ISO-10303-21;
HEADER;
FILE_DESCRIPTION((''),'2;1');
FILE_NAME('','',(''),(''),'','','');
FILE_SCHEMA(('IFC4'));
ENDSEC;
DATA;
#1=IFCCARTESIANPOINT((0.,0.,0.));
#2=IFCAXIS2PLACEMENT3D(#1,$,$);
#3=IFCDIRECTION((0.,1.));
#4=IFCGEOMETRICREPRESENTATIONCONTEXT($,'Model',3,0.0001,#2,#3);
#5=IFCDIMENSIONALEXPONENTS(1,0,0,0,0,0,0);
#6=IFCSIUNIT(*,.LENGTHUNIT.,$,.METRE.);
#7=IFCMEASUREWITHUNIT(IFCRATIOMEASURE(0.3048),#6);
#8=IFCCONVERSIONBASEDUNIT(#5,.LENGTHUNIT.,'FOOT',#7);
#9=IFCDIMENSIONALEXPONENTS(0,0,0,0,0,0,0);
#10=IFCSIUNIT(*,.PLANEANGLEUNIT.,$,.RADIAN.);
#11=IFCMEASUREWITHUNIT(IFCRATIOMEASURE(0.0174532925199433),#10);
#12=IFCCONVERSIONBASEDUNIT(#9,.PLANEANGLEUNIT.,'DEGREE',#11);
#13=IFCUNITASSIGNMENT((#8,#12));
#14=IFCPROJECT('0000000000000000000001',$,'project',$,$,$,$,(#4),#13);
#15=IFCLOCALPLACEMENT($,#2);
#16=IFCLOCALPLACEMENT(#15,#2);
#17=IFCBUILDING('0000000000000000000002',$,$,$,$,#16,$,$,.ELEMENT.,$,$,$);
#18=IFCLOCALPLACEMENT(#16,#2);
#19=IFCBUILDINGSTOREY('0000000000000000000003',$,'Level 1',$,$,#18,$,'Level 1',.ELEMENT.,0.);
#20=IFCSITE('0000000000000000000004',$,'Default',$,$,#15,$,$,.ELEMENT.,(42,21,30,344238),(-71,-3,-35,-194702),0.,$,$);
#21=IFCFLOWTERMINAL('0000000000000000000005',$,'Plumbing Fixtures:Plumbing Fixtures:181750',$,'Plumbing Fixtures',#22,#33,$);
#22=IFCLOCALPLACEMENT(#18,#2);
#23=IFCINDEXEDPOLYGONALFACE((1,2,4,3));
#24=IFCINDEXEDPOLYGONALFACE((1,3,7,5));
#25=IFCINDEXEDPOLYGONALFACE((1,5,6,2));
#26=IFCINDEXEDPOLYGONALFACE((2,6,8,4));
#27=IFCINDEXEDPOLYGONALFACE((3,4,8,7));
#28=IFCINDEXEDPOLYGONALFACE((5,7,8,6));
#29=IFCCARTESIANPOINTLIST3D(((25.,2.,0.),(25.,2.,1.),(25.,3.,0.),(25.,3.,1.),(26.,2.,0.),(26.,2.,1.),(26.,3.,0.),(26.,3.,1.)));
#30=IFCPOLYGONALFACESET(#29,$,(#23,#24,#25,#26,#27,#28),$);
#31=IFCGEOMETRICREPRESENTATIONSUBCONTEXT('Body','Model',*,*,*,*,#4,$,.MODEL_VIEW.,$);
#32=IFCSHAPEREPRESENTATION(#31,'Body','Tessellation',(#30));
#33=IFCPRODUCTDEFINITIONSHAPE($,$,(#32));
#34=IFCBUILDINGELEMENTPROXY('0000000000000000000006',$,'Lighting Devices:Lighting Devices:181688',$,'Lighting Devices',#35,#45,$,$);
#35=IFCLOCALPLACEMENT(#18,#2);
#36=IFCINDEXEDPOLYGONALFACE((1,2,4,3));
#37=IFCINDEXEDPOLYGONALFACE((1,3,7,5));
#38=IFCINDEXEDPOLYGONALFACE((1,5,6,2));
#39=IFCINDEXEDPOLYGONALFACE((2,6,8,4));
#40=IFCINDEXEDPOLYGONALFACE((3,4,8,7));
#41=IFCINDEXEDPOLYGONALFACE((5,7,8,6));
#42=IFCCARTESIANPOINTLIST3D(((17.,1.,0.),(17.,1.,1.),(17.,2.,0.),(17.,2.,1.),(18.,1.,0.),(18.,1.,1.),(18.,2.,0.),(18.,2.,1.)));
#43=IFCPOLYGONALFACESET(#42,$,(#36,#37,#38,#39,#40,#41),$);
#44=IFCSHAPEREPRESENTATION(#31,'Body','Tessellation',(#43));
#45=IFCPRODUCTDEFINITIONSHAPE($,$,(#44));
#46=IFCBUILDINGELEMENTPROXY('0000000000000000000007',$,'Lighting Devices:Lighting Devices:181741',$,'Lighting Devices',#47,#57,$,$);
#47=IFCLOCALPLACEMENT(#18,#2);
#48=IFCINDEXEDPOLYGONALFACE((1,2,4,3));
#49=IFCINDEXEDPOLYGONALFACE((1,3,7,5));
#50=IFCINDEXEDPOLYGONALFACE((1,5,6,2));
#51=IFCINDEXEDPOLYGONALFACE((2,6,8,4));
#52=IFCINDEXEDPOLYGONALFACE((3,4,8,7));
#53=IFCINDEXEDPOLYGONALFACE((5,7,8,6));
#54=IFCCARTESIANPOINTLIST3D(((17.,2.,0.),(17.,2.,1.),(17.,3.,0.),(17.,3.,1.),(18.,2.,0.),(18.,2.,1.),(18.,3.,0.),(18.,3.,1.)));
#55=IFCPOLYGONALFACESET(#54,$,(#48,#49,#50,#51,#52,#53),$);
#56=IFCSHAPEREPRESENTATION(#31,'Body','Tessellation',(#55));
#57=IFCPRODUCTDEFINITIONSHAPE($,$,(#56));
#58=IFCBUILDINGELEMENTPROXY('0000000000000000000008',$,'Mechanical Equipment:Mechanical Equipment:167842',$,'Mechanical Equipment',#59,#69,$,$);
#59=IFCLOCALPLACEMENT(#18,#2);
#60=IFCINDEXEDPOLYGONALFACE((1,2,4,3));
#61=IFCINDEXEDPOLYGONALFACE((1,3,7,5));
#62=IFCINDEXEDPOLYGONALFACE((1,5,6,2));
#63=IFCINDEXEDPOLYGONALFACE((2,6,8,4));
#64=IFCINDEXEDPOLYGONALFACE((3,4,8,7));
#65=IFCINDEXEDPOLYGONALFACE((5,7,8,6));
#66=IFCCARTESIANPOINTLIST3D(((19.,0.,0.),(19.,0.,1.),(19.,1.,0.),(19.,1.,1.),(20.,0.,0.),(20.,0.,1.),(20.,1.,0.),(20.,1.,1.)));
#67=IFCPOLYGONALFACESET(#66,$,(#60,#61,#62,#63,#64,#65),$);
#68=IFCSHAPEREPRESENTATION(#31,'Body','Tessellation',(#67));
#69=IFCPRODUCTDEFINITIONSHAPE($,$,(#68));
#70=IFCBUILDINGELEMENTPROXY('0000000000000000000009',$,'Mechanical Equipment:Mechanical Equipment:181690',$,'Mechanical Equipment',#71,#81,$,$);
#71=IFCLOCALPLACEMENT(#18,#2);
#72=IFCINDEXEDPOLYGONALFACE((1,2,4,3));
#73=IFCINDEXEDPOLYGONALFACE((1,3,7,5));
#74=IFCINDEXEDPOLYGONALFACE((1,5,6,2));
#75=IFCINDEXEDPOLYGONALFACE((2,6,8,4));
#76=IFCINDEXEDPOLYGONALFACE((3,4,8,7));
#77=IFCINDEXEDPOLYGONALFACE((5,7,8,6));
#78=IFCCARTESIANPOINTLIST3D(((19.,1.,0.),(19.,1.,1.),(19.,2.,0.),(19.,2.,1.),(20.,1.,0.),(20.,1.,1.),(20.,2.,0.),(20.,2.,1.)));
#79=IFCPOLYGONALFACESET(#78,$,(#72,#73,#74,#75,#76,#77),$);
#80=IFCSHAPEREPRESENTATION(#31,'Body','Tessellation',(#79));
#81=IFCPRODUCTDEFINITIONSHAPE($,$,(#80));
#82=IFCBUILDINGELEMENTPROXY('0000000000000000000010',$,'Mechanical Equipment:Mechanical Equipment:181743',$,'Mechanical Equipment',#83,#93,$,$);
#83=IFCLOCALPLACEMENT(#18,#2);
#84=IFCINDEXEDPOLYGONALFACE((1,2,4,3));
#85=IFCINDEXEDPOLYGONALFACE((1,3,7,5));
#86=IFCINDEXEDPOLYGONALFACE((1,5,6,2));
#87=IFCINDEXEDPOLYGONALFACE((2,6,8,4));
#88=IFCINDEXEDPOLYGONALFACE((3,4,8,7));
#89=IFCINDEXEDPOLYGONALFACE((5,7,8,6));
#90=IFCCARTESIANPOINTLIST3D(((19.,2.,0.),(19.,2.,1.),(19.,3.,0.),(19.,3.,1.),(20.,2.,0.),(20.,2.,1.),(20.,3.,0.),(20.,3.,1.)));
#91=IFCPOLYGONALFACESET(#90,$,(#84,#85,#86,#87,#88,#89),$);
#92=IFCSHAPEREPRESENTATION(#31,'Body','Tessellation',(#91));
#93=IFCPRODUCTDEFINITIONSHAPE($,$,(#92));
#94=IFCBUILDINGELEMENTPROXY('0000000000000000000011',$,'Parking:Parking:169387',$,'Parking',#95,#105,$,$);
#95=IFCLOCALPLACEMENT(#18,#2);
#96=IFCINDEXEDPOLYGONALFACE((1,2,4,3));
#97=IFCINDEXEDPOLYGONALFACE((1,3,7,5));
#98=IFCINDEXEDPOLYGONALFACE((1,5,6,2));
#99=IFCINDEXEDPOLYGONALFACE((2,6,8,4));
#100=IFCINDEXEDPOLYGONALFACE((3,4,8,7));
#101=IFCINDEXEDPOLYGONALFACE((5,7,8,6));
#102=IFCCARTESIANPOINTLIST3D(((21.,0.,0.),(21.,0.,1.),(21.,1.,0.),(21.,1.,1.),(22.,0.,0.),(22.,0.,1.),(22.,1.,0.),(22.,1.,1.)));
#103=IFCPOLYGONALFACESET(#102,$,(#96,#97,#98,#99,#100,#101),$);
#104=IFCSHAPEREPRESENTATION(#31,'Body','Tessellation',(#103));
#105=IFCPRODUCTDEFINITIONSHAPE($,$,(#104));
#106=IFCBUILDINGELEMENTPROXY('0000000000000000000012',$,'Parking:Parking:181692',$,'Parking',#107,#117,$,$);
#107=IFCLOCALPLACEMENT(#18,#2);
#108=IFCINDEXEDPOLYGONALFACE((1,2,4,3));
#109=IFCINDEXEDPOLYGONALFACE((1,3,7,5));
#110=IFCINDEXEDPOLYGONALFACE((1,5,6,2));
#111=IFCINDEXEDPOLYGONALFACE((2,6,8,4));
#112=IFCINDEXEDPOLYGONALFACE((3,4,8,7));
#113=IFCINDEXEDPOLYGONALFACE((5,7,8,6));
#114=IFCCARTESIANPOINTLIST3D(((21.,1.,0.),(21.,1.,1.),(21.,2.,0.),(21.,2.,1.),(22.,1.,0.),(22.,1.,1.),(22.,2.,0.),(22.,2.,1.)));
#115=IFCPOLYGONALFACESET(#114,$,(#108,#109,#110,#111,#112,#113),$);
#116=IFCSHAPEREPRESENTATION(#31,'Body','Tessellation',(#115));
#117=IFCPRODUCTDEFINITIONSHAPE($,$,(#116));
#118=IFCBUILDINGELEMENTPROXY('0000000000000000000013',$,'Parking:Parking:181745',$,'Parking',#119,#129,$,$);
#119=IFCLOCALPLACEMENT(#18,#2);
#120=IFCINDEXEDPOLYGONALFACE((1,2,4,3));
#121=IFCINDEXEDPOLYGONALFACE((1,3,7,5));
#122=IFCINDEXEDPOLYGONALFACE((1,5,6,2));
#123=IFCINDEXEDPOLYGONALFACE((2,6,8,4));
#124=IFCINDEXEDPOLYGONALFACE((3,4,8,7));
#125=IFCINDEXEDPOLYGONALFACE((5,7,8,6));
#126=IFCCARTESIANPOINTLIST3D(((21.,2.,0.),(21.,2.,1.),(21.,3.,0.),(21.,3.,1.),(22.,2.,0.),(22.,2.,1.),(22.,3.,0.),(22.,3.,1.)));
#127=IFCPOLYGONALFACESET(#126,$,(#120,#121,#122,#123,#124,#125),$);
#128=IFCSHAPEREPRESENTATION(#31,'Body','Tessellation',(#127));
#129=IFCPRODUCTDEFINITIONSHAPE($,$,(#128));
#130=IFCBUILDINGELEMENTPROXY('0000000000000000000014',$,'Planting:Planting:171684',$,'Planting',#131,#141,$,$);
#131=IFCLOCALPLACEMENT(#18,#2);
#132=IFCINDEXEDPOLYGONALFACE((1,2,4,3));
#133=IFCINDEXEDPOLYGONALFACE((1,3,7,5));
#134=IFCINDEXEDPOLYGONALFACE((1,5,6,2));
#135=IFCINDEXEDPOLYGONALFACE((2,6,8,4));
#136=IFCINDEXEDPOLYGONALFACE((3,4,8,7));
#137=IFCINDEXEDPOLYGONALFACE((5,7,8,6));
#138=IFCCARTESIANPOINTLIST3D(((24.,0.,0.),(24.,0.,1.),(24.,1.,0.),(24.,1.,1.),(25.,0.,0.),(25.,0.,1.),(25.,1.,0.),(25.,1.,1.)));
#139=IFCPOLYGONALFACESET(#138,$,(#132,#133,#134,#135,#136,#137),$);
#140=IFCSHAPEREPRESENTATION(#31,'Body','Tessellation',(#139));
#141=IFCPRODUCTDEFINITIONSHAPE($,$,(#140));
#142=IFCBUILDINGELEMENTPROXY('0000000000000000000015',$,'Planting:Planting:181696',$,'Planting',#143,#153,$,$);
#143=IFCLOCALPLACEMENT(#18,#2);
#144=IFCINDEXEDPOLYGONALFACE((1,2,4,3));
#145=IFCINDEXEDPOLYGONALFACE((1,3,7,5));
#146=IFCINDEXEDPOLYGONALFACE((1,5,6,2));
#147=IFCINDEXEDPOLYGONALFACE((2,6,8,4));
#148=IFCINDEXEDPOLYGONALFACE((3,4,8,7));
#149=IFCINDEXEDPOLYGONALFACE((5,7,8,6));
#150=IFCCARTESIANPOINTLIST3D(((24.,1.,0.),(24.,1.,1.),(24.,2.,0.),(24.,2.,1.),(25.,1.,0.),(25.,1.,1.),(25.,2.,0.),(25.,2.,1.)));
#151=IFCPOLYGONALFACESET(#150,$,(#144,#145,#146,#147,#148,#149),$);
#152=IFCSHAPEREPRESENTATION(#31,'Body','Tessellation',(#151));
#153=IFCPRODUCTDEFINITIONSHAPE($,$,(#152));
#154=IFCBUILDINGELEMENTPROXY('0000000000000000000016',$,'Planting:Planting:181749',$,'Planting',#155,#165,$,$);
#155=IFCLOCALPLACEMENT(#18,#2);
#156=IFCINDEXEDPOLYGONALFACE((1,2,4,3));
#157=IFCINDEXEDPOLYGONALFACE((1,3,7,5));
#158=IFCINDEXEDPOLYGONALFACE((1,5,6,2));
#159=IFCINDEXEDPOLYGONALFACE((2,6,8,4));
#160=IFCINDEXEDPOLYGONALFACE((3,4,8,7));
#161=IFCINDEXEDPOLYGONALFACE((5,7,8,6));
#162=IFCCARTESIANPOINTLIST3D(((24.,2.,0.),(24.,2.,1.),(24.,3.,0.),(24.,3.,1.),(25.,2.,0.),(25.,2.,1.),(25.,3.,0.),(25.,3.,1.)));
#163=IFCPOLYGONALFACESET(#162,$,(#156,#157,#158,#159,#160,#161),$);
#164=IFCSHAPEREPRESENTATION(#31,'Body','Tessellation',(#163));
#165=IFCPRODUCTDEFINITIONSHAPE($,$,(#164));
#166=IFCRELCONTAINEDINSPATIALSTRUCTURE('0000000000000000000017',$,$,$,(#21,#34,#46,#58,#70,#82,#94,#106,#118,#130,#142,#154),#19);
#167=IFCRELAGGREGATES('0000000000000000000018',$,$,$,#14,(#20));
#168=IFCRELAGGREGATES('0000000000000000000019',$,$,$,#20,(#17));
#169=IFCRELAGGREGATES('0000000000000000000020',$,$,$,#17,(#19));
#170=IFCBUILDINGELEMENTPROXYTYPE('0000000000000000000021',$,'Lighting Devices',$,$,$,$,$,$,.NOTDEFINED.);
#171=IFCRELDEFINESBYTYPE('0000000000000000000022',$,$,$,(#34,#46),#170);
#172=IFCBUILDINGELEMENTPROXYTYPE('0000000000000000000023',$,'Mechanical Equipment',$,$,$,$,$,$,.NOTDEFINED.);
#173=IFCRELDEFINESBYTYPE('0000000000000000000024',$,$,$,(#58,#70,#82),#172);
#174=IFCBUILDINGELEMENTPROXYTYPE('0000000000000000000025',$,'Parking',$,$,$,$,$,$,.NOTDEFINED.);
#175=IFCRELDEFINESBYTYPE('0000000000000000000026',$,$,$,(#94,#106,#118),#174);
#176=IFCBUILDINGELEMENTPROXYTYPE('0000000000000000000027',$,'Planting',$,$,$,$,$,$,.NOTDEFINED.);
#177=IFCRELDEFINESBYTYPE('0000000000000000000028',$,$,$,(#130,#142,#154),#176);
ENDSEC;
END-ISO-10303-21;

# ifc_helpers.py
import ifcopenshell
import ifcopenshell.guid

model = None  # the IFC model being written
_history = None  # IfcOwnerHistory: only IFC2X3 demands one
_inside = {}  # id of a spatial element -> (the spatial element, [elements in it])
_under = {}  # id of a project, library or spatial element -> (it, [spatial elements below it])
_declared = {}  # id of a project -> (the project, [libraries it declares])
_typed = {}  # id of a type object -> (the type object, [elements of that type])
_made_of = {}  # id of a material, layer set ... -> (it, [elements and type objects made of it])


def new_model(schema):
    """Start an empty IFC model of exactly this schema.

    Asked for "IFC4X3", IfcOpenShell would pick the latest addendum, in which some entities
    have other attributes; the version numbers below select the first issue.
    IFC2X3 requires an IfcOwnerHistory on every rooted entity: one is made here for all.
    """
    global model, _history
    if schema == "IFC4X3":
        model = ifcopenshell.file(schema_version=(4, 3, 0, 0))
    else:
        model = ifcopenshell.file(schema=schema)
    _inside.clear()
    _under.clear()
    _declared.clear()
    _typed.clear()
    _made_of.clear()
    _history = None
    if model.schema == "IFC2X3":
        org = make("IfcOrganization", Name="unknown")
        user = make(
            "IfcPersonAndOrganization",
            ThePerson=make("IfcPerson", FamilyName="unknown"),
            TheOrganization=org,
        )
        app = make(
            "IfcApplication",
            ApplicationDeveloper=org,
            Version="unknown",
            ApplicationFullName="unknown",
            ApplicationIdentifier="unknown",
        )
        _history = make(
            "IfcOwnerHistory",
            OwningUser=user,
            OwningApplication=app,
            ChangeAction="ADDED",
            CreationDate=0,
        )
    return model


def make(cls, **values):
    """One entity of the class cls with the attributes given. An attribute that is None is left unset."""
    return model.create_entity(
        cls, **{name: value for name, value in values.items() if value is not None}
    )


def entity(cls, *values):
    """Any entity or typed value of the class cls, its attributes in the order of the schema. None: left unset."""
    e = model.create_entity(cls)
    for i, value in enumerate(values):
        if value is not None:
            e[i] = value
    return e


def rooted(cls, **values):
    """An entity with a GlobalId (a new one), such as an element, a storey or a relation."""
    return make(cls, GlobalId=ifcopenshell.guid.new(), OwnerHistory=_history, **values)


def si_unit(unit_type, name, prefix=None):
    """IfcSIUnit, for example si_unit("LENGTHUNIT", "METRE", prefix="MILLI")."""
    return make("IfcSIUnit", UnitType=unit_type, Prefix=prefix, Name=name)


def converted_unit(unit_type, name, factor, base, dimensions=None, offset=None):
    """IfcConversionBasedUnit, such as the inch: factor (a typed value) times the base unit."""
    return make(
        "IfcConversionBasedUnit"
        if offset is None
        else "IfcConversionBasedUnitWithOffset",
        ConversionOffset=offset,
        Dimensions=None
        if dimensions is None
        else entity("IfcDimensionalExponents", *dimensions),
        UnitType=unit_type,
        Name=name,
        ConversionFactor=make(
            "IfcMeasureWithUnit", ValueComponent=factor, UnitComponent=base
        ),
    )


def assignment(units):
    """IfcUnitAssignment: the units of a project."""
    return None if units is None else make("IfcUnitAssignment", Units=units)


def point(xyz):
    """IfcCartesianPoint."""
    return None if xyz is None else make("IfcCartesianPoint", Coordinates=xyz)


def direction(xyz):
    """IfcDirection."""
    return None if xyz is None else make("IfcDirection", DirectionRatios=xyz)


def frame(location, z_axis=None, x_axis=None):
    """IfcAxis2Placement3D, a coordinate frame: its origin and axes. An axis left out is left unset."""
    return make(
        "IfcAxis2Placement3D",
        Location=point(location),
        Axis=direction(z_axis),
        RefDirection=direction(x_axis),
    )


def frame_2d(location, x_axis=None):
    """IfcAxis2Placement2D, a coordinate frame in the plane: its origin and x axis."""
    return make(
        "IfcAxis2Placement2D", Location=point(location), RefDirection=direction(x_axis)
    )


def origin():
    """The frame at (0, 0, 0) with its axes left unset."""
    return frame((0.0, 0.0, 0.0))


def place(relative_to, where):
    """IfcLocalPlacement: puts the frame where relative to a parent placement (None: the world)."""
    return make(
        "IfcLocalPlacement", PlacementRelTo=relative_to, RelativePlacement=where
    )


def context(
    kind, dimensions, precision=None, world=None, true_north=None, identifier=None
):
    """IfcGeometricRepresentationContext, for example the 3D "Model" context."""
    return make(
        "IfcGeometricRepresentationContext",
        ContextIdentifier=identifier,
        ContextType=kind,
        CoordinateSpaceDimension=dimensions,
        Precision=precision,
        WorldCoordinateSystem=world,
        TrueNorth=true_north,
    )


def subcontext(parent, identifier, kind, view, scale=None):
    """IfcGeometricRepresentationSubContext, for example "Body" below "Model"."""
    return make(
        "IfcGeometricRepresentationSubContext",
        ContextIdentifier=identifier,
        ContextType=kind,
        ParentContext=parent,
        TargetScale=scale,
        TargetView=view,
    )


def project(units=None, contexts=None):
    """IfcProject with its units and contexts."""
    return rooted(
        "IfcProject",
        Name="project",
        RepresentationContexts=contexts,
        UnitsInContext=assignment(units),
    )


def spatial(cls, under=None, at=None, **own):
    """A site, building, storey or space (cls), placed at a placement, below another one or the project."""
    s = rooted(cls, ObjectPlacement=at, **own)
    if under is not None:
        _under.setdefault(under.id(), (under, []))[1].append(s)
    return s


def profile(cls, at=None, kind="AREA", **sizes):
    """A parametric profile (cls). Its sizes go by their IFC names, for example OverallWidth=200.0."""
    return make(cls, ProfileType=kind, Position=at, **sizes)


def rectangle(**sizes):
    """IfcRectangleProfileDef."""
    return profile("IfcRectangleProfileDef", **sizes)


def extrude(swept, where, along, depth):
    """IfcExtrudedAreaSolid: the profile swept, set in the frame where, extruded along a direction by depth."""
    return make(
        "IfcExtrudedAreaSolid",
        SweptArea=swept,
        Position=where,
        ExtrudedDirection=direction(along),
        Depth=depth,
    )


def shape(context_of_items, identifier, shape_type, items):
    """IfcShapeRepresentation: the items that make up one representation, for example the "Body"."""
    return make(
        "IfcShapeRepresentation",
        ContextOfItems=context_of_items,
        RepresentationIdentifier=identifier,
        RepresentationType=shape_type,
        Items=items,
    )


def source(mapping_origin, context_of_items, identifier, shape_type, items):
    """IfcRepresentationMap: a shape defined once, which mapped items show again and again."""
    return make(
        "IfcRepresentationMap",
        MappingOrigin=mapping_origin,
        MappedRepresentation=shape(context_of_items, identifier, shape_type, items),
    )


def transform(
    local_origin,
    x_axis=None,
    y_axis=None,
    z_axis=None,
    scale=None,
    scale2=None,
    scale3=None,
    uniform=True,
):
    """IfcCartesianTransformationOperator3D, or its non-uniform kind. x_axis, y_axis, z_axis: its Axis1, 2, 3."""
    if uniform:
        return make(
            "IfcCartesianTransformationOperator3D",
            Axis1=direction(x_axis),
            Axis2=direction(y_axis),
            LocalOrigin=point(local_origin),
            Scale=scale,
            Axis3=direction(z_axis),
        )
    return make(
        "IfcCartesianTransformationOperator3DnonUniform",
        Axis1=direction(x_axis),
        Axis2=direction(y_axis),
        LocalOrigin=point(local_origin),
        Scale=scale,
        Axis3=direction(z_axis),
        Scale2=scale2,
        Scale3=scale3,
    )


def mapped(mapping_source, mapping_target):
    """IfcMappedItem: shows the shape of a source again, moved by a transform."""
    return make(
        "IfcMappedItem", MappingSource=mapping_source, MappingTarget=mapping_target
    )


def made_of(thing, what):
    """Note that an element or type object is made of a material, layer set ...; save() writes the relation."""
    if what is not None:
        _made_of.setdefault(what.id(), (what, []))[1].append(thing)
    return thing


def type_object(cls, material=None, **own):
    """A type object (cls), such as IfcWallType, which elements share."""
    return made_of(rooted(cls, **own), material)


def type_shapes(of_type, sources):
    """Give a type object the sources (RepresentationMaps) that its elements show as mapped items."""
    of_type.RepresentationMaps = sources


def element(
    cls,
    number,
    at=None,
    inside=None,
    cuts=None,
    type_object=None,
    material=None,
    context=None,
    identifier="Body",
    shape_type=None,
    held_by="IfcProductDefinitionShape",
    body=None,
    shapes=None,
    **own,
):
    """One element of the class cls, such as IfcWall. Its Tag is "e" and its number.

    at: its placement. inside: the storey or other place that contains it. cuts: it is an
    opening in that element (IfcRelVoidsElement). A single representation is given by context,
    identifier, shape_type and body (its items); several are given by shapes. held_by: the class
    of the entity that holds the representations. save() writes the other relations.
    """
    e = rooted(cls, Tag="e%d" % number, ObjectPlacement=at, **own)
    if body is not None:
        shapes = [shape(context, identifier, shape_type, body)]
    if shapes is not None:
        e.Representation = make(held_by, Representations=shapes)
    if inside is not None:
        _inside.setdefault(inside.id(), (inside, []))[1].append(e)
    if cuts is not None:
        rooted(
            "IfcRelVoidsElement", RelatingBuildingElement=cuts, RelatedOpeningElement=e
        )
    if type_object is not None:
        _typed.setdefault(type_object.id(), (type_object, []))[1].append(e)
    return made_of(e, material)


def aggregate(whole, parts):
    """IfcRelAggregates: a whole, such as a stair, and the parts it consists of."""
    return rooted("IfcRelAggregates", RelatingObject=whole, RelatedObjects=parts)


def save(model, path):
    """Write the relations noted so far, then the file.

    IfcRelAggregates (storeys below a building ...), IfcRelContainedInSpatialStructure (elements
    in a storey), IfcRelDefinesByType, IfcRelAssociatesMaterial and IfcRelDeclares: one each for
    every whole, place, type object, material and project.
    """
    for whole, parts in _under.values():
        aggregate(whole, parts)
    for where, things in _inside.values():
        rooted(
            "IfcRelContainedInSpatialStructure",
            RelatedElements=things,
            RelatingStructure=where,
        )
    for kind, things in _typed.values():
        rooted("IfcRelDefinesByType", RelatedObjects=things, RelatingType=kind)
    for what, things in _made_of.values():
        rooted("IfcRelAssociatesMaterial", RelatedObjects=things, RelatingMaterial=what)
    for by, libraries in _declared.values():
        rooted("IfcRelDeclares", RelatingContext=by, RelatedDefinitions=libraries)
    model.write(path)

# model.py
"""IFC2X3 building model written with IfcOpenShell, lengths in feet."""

from ifc_helpers import new_model, entity, si_unit, converted_unit, direction, frame, frame_2d, origin, place, context, subcontext, project, spatial, rectangle, extrude, source, transform, mapped, type_object, type_shapes, element, save


model = new_model("IFC2X3")

# Units and contexts
model_context = context("Model", 3, precision=0.0001, world=origin(), true_north=direction((0.0, 1.0)))
body_context = subcontext(model_context, "Body", "Model", "MODEL_VIEW")
ifc_project = project(units=[converted_unit("LENGTHUNIT", "FOOT", entity("IfcRatioMeasure", 0.3048), si_unit("LENGTHUNIT", "METRE"), dimensions=[1, 0, 0, 0, 0, 0, 0]), converted_unit("PLANEANGLEUNIT", "DEGREE", entity("IfcRatioMeasure", 0.0174532925199433), si_unit("PLANEANGLEUNIT", "RADIAN"), dimensions=[0, 0, 0, 0, 0, 0, 0])], contexts=[model_context])

# Site, building, storey
site_placement = place(None, origin())
site = spatial("IfcSite", under=ifc_project, at=site_placement, Name="Default", CompositionType="ELEMENT", RefLatitude=(42, 21, 30, 344238), RefLongitude=(-71, -3, -35, -194702), RefElevation=0.0)
building_placement = place(site_placement, origin())
building = spatial("IfcBuilding", under=site, at=building_placement, CompositionType="ELEMENT")
storey_placement = place(building_placement, origin())
storey = spatial("IfcBuildingStorey", under=building, at=storey_placement, Name="Level 1", LongName="Level 1", CompositionType="ELEMENT", Elevation=0.0)

# Flow terminal
shared_shape_1 = source(origin(), body_context, "Body", "SweptSolid", [
    extrude(rectangle(XDim=1.0, YDim=1.0, at=frame_2d((0.0, 0.0), x_axis=(1.0, 0.0))), frame((0.5, 0.5, 0.0), z_axis=(0.0, 0.0, 1.0), x_axis=(0.0, 1.0, 0.0)), (0.0, 0.0, 1.0), 1.0),
])
for number, where, name in (
    (1, (25.0, 2.0, 0.0), "Plumbing Fixtures:Plumbing Fixtures:181750"),
):
    element("IfcFlowTerminal", number, at=place(storey_placement, frame(where)), inside=storey, Name=name, ObjectType="Plumbing Fixtures", context=body_context, shape_type="MappedRepresentation", body=[
        mapped(shared_shape_1, transform((0.0, 0.0, 0.0), scale=1.0)),
    ])

# Building element proxies
building_element_proxy_type_1 = type_object("IfcBuildingElementProxyType", Name="Lighting Devices", PredefinedType="NOTDEFINED")
shared_shape_2 = source(origin(), body_context, "Body", "SweptSolid", [
    extrude(rectangle(XDim=1.0, YDim=1.0, at=frame_2d((0.0, 0.0), x_axis=(1.0, 0.0))), frame((0.5, 0.5, 0.0), z_axis=(0.0, 0.0, 1.0), x_axis=(0.0, 1.0, 0.0)), (0.0, 0.0, 1.0), 1.0),
])
type_shapes(building_element_proxy_type_1, [shared_shape_2])
for number, where, name in (
    (2, (17.0, 1.0, 0.0), "Lighting Devices:Lighting Devices:181688"),
    (3, (17.0, 2.0, 0.0), "Lighting Devices:Lighting Devices:181741"),
):
    element("IfcBuildingElementProxy", number, at=place(storey_placement, frame(where)), inside=storey, type_object=building_element_proxy_type_1, Name=name, ObjectType="Lighting Devices", context=body_context, shape_type="MappedRepresentation", body=[
        mapped(shared_shape_2, transform((0.0, 0.0, 0.0), scale=1.0)),
    ])
building_element_proxy_type_2 = type_object("IfcBuildingElementProxyType", Name="Mechanical Equipment", PredefinedType="NOTDEFINED")
shared_shape_3 = source(origin(), body_context, "Body", "SweptSolid", [
    extrude(rectangle(XDim=1.0, YDim=1.0, at=frame_2d((0.0, 0.0), x_axis=(1.0, 0.0))), frame((0.5, 0.5, 0.0), z_axis=(0.0, 0.0, 1.0), x_axis=(0.0, 1.0, 0.0)), (0.0, 0.0, 1.0), 1.0),
])
type_shapes(building_element_proxy_type_2, [shared_shape_3])
for number, where, name in (
    (4, (19.0, 0.0, 0.0), "Mechanical Equipment:Mechanical Equipment:167842"),
    (5, (19.0, 1.0, 0.0), "Mechanical Equipment:Mechanical Equipment:181690"),
    (6, (19.0, 2.0, 0.0), "Mechanical Equipment:Mechanical Equipment:181743"),
):
    element("IfcBuildingElementProxy", number, at=place(storey_placement, frame(where)), inside=storey, type_object=building_element_proxy_type_2, Name=name, ObjectType="Mechanical Equipment", context=body_context, shape_type="MappedRepresentation", body=[
        mapped(shared_shape_3, transform((0.0, 0.0, 0.0), scale=1.0)),
    ])
building_element_proxy_type_3 = type_object("IfcBuildingElementProxyType", Name="Parking", PredefinedType="NOTDEFINED")
shared_shape_4 = source(origin(), body_context, "Body", "SweptSolid", [
    extrude(rectangle(XDim=1.0, YDim=1.0, at=frame_2d((0.0, 0.0), x_axis=(1.0, 0.0))), frame((0.5, 0.5, 0.0), z_axis=(0.0, 0.0, 1.0), x_axis=(0.0, 1.0, 0.0)), (0.0, 0.0, 1.0), 1.0),
])
type_shapes(building_element_proxy_type_3, [shared_shape_4])
for number, where, name in (
    (7, (21.0, 0.0, 0.0), "Parking:Parking:169387"),
    (8, (21.0, 1.0, 0.0), "Parking:Parking:181692"),
    (9, (21.0, 2.0, 0.0), "Parking:Parking:181745"),
):
    element("IfcBuildingElementProxy", number, at=place(storey_placement, frame(where)), inside=storey, type_object=building_element_proxy_type_3, Name=name, ObjectType="Parking", context=body_context, shape_type="MappedRepresentation", body=[
        mapped(shared_shape_4, transform((0.0, 0.0, 0.0), scale=1.0)),
    ])
building_element_proxy_type_4 = type_object("IfcBuildingElementProxyType", Name="Planting", PredefinedType="NOTDEFINED")
shared_shape_5 = source(origin(), body_context, "Body", "SweptSolid", [
    extrude(rectangle(XDim=1.0, YDim=1.0, at=frame_2d((0.0, 0.0), x_axis=(1.0, 0.0))), frame((0.5, 0.5, 0.0), z_axis=(0.0, 0.0, 1.0), x_axis=(0.0, 1.0, 0.0)), (0.0, 0.0, 1.0), 1.0),
])
type_shapes(building_element_proxy_type_4, [shared_shape_5])
for number, where, name in (
    (10, (24.0, 0.0, 0.0), "Planting:Planting:171684"),
    (11, (24.0, 1.0, 0.0), "Planting:Planting:181696"),
    (12, (24.0, 2.0, 0.0), "Planting:Planting:181749"),
):
    element("IfcBuildingElementProxy", number, at=place(storey_placement, frame(where)), inside=storey, type_object=building_element_proxy_type_4, Name=name, ObjectType="Planting", context=body_context, shape_type="MappedRepresentation", body=[
        mapped(shared_shape_5, transform((0.0, 0.0, 0.0), scale=1.0)),
    ])

save(model, "model.ifc")
